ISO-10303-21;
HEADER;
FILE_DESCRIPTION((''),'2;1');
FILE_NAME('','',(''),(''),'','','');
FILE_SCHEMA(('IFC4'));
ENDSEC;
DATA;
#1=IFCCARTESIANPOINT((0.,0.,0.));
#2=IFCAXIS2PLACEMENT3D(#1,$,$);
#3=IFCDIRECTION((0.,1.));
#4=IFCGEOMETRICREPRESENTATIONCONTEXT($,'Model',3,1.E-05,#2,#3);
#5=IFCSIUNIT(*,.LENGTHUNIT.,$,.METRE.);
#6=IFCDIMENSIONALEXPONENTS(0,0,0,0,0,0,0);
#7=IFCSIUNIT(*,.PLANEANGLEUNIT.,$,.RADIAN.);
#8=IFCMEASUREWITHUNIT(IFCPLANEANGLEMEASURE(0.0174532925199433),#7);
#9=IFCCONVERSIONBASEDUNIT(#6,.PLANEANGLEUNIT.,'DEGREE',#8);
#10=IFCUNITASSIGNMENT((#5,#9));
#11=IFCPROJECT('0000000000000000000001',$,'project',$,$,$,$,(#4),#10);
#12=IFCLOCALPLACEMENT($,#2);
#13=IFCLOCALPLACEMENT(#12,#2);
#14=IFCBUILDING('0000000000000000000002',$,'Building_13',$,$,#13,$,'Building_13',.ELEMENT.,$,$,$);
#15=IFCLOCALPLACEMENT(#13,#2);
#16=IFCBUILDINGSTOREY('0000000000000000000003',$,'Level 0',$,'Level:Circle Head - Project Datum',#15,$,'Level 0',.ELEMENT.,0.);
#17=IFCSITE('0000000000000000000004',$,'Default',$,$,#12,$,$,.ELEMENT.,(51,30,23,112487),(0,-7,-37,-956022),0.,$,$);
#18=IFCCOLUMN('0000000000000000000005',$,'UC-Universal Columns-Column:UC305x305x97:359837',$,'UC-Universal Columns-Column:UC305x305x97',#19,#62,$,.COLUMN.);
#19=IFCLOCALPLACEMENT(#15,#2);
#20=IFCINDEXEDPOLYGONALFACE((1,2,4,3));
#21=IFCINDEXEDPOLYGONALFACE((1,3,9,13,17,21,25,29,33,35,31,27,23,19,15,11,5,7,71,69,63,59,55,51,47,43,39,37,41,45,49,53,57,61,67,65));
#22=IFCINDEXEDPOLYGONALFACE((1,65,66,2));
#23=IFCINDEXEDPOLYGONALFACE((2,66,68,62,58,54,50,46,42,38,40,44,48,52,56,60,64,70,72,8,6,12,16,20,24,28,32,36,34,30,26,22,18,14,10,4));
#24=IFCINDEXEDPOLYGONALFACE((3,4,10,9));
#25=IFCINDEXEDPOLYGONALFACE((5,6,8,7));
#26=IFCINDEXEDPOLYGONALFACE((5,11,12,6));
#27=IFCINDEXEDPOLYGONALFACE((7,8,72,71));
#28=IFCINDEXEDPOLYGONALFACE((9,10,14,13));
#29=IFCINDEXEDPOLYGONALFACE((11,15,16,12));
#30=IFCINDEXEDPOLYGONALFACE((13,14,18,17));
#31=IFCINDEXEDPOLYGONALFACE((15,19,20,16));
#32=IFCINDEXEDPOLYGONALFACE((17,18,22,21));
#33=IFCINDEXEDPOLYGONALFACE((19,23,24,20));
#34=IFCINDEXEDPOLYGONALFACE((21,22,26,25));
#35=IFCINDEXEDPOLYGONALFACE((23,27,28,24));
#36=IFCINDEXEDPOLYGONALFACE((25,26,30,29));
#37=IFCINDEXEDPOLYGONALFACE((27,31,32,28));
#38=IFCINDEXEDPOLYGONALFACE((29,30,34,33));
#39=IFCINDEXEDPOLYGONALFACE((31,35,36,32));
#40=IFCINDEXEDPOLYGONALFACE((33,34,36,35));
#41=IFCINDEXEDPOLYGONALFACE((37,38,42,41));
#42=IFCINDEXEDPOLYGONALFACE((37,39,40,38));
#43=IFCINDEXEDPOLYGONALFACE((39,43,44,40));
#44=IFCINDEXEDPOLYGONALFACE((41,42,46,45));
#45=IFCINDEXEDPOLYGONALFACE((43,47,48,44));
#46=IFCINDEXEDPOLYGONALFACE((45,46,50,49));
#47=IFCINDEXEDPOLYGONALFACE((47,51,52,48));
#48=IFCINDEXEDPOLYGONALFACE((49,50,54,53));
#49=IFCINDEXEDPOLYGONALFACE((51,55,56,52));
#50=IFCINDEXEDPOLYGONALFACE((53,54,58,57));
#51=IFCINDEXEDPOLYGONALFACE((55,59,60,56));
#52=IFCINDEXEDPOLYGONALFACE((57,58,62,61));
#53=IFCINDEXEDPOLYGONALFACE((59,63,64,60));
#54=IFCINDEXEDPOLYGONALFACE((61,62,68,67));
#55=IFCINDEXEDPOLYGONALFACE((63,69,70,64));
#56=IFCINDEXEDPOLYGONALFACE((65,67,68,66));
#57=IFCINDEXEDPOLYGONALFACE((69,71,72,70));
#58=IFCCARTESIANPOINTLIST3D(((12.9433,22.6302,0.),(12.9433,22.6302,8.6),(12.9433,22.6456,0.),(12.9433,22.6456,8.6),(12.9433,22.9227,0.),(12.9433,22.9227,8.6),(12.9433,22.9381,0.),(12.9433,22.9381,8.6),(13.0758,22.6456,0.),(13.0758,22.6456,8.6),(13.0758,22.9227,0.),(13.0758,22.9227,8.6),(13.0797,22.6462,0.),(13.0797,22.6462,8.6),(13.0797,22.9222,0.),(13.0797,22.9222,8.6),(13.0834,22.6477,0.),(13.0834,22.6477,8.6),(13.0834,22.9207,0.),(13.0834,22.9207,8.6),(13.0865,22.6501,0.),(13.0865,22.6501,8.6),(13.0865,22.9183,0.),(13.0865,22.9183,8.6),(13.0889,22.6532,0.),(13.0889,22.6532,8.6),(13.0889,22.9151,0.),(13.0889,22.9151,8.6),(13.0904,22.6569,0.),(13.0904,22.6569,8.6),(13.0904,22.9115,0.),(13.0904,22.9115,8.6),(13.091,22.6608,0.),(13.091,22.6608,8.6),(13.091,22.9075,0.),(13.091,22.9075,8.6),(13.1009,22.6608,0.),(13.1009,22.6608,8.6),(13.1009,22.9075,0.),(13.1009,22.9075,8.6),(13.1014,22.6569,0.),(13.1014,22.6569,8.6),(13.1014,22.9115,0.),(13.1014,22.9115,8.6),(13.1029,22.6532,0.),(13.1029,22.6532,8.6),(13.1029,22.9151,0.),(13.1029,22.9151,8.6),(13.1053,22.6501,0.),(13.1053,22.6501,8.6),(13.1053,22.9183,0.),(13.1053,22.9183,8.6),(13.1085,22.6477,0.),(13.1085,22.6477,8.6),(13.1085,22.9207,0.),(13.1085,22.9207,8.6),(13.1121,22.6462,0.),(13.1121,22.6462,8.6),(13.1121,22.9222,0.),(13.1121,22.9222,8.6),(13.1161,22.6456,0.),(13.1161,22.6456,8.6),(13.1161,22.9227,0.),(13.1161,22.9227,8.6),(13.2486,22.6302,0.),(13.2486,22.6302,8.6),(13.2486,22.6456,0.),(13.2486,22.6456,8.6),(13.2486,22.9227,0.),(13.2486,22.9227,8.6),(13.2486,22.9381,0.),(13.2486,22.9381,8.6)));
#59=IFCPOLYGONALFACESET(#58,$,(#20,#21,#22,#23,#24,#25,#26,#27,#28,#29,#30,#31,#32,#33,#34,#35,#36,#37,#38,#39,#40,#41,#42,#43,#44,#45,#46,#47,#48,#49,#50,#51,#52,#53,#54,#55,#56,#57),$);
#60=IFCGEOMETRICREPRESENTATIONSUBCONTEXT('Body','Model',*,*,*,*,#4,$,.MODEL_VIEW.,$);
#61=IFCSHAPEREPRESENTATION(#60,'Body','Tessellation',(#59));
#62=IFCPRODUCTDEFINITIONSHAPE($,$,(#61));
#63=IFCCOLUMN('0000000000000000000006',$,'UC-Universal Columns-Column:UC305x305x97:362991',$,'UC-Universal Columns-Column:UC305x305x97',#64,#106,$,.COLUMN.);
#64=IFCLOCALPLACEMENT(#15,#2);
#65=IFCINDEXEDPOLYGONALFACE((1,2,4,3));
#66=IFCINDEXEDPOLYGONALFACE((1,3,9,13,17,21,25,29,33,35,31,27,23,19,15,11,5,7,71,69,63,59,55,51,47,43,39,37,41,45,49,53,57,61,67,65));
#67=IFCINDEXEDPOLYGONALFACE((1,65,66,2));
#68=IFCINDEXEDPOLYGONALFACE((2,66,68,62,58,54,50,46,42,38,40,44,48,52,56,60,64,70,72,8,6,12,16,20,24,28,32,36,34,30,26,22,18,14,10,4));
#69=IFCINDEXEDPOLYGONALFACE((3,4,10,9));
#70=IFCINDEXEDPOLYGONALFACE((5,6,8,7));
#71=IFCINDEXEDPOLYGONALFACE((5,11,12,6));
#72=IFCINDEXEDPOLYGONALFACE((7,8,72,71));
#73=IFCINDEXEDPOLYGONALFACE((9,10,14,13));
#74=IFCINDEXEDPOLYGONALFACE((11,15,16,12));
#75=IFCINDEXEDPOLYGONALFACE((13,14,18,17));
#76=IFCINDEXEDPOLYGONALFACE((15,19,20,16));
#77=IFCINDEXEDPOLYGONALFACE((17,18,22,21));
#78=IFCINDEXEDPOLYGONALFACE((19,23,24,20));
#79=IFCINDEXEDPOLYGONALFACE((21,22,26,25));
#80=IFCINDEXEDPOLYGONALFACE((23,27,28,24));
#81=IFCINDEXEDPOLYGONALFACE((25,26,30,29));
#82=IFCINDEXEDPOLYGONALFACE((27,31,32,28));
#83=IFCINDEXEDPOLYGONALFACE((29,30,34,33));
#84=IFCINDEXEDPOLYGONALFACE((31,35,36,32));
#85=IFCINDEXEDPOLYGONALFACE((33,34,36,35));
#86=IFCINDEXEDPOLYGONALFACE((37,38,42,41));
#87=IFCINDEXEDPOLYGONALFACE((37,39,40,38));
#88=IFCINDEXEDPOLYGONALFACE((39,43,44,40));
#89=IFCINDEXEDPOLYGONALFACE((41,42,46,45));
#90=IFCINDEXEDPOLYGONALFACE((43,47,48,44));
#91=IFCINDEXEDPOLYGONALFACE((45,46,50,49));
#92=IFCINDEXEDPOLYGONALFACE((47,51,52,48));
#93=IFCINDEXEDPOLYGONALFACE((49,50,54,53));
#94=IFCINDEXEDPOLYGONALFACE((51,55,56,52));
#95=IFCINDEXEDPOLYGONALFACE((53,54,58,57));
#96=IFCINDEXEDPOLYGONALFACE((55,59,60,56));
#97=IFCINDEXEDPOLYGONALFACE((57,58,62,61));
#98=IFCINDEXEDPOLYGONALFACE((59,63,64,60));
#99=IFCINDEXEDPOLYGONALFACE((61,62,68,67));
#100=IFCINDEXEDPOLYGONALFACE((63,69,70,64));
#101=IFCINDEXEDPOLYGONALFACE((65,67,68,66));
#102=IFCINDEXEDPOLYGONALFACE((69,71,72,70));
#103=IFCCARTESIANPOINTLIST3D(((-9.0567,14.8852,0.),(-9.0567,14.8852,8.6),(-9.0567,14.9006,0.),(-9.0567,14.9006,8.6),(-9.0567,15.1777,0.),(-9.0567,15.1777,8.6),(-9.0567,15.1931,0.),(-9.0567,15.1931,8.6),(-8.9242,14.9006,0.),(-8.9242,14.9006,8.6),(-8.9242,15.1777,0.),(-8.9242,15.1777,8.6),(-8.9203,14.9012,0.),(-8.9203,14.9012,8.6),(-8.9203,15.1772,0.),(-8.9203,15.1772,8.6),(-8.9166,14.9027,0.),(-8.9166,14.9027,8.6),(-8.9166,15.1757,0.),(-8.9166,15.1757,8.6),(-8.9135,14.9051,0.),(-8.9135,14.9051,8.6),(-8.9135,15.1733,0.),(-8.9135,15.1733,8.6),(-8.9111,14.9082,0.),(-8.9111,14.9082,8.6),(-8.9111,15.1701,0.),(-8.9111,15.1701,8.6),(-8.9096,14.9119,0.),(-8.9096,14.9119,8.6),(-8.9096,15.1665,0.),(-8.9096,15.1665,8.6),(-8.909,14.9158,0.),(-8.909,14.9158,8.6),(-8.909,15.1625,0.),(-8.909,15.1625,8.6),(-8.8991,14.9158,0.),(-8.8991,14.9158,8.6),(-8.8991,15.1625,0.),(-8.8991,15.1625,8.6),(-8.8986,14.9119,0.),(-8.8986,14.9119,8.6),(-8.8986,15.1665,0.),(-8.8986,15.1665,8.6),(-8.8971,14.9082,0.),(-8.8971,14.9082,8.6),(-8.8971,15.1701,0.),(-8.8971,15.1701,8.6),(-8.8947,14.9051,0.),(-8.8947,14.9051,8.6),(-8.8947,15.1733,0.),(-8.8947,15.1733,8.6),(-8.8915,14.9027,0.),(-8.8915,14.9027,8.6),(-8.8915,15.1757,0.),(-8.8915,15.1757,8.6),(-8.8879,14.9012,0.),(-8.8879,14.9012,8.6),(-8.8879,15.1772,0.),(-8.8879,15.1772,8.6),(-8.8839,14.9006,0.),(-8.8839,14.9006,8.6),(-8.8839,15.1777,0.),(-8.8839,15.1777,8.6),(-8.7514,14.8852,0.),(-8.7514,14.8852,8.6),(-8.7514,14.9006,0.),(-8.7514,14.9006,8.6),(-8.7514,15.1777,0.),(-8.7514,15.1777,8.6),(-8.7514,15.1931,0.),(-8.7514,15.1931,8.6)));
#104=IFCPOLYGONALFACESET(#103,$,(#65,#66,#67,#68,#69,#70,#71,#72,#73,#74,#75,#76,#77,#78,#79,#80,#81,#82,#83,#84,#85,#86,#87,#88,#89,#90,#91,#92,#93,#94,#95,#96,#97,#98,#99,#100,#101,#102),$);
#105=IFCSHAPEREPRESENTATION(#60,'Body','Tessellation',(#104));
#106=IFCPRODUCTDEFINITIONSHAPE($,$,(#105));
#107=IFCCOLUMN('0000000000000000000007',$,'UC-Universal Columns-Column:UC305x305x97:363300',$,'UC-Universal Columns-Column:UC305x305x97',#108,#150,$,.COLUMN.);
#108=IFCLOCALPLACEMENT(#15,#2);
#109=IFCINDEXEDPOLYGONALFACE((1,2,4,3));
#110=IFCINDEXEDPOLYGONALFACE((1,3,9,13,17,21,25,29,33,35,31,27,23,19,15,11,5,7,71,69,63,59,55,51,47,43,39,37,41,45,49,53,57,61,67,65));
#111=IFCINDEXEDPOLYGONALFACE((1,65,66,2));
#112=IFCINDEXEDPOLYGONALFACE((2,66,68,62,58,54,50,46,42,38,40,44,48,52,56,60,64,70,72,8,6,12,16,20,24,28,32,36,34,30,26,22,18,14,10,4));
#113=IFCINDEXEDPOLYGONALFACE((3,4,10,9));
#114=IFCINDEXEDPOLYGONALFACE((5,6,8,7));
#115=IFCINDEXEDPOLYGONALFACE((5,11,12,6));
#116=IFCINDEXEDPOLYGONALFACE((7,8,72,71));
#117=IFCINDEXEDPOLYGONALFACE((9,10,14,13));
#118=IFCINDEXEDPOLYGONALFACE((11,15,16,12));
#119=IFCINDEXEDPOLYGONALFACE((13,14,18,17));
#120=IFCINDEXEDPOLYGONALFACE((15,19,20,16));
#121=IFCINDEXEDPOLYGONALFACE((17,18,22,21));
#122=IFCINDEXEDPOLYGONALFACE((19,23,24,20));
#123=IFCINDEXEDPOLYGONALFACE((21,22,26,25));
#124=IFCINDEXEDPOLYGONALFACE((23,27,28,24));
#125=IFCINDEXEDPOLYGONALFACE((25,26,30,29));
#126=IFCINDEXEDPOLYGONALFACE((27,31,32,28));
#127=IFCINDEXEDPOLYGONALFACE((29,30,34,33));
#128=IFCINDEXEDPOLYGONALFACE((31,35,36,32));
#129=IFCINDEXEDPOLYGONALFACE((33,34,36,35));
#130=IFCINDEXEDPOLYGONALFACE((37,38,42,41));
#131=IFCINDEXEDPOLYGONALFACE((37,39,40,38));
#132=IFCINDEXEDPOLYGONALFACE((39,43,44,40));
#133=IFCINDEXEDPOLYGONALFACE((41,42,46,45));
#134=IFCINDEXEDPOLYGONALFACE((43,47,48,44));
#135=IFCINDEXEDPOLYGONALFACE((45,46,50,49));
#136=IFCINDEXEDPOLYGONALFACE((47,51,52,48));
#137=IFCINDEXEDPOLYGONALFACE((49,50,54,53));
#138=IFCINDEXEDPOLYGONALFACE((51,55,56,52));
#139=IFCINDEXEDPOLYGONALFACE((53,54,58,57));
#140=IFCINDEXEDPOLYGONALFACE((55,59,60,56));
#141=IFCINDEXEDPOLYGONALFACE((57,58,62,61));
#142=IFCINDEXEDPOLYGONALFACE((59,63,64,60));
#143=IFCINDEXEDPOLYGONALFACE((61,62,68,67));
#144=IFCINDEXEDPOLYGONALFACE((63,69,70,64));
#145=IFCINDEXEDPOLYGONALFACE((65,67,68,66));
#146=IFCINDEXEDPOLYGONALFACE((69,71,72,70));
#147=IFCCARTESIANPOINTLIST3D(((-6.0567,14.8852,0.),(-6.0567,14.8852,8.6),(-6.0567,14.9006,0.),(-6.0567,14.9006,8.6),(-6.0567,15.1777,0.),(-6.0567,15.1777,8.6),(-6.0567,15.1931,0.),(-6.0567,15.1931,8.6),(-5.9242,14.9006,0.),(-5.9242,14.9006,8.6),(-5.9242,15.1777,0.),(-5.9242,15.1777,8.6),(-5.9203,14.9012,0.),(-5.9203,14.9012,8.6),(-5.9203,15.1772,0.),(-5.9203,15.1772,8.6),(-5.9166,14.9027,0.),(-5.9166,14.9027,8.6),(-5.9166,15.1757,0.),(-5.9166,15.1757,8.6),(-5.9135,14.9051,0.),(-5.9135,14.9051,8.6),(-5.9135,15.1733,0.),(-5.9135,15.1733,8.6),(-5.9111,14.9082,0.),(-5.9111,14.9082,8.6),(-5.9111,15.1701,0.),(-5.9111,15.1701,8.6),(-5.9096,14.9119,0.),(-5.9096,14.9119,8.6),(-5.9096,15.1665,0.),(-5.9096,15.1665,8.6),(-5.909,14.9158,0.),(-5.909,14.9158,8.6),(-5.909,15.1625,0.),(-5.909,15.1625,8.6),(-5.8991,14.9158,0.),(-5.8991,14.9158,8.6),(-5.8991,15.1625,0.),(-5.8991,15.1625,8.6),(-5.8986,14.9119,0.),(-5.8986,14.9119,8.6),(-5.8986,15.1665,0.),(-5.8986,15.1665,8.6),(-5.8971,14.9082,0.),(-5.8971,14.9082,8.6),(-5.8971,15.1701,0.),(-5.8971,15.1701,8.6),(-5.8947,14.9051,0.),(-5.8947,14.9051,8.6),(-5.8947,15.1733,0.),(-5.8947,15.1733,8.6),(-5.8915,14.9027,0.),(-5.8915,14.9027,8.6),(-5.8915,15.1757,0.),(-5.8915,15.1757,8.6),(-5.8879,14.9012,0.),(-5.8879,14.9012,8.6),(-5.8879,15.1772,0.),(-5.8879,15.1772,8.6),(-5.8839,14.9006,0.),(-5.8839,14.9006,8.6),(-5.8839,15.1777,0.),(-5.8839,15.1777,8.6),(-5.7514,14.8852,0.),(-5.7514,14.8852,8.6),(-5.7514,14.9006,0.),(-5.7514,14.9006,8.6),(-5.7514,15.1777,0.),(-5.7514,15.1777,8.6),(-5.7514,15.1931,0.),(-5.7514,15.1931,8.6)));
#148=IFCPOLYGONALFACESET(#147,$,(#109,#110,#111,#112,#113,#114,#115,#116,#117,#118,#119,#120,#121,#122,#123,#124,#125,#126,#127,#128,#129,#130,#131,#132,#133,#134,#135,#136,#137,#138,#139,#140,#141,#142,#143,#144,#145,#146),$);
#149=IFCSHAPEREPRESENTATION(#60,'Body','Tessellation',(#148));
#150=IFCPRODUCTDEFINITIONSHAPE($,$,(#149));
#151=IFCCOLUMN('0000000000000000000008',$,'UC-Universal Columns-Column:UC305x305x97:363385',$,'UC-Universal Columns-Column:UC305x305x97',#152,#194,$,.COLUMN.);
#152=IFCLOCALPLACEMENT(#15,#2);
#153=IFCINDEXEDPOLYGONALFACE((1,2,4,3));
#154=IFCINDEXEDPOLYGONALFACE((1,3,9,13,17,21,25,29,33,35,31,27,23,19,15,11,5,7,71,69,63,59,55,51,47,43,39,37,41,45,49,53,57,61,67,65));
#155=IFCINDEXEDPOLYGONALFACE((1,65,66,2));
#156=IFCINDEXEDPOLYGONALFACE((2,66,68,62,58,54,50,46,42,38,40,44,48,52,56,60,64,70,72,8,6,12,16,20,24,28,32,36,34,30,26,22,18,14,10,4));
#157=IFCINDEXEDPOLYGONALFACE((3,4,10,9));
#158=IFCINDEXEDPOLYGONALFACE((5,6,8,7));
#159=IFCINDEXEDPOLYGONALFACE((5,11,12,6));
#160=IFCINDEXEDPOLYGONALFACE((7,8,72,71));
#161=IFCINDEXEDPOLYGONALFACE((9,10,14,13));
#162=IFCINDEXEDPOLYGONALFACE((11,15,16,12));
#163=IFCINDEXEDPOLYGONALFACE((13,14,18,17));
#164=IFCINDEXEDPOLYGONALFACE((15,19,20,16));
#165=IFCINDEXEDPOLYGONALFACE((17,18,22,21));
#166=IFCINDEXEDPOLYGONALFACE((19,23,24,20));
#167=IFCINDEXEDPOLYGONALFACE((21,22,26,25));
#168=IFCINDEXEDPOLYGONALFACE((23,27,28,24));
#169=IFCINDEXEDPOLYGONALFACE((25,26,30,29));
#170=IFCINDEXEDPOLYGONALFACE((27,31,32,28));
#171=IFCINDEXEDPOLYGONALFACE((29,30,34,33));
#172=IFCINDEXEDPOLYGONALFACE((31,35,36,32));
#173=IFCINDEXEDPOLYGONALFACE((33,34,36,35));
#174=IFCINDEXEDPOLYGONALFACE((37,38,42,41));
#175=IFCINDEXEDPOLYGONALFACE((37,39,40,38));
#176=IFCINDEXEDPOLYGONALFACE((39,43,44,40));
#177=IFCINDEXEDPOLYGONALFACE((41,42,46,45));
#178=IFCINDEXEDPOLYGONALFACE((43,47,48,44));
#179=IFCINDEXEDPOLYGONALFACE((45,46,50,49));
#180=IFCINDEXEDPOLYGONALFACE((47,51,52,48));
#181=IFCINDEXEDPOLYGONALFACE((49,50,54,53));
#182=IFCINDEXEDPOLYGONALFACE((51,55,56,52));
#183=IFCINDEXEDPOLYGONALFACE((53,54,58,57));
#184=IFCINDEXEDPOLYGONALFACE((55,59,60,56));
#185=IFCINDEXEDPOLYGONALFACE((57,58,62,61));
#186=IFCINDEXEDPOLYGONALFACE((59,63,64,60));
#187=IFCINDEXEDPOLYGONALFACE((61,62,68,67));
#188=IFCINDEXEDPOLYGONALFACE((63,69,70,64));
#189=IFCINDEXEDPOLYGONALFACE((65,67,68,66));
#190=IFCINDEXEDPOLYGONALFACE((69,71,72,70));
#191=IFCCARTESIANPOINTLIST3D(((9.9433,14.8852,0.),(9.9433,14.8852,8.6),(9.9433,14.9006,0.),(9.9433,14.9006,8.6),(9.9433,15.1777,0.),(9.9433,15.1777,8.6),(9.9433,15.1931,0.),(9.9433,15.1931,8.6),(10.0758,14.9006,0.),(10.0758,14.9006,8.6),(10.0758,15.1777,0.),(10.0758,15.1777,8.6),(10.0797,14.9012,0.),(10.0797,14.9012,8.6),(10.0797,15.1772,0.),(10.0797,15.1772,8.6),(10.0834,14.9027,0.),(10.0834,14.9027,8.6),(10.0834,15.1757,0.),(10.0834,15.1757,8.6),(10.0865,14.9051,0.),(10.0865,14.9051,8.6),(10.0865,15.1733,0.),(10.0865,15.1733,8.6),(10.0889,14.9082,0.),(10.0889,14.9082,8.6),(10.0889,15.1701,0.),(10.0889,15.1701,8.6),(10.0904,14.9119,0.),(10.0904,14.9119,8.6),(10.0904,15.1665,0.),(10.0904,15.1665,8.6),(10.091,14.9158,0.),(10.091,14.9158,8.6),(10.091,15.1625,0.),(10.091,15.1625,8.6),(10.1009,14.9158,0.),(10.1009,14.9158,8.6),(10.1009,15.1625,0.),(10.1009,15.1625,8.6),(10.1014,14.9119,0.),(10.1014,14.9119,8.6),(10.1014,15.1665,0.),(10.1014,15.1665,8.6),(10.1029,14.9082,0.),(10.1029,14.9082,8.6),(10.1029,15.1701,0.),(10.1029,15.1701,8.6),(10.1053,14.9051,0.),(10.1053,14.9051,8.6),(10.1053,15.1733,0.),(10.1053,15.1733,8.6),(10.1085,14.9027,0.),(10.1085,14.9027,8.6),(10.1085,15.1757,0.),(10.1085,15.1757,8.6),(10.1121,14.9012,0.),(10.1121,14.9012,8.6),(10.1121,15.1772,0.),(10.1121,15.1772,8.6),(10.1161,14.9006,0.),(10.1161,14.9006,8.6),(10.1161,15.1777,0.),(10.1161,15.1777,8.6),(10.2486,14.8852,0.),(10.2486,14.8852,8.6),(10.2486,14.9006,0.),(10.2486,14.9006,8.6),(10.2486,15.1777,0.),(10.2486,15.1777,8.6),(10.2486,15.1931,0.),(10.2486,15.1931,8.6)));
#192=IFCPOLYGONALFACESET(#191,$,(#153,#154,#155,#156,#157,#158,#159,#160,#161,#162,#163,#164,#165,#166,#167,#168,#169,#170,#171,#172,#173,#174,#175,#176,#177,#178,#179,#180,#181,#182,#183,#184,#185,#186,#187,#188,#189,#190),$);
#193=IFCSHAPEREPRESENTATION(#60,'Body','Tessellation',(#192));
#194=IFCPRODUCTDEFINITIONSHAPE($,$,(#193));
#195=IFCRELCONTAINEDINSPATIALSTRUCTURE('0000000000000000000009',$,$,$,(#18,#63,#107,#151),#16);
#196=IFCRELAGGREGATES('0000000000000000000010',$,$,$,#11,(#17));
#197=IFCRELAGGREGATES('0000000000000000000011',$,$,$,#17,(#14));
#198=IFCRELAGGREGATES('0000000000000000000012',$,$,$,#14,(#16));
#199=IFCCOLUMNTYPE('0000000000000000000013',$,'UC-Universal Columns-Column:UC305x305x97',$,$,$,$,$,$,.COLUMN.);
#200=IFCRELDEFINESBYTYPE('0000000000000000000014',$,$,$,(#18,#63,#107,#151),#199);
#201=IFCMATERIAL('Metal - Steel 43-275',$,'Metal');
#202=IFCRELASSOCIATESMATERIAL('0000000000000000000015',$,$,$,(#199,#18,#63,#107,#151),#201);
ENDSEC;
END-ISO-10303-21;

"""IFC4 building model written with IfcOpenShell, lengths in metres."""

from ifc_helpers import new_model, entity, si_unit, converted_unit, direction, frame, origin, place, context, subcontext, project, spatial, line, arc, indexed_curve, outline, extrude, source, transform, mapped, material, type_object, type_shapes, element, save


model = new_model("IFC4")

# Units and contexts
model_context = context("Model", 3, precision=1e-05, world=origin(), true_north=direction((0.0, 1.0)))
body_context = subcontext(model_context, "Body", "Model", "MODEL_VIEW")
ifc_project = project(units=[si_unit("LENGTHUNIT", "METRE"), converted_unit("PLANEANGLEUNIT", "DEGREE", entity("IfcPlaneAngleMeasure", 0.0174532925199433), si_unit("PLANEANGLEUNIT", "RADIAN"), dimensions=[0, 0, 0, 0, 0, 0, 0])], contexts=[model_context])

# Site, building, storey
site_placement = place(None, origin())
site = spatial("IfcSite", under=ifc_project, at=site_placement, Name="Default", CompositionType="ELEMENT", RefLatitude=(51, 30, 23, 112487), RefLongitude=(0, -7, -37, -956022), RefElevation=0.0)
building_placement = place(site_placement, origin())
building = spatial("IfcBuilding", under=site, at=building_placement, Name="Building_13", LongName="Building_13", CompositionType="ELEMENT")
storey_placement = place(building_placement, origin())
storey = spatial("IfcBuildingStorey", under=building, at=storey_placement, Name="Level 0", ObjectType="Level:Circle Head - Project Datum", LongName="Level 0", CompositionType="ELEMENT", Elevation=0.0)

# Columns
ifc_material_1 = material(Name="Metal - Steel 43-275", Category="Metal")
column_type_1 = type_object("IfcColumnType", Name="UC-Universal Columns-Column:UC305x305x97", PredefinedType="COLUMN", material=ifc_material_1)
shared_shape_1 = source(origin(), body_context, "Body", "SweptSolid", [
    extrude(outline(indexed_curve([(-0.1527, -0.154), (0.1527, -0.154), (0.1527, -0.1386), (0.0202, -0.1386), (0.0094, -0.1341), (0.0049, -0.1234), (0.0049, 0.1234), (0.0094, 0.1341), (0.0202, 0.1386), (0.1527, 0.1386), (0.1527, 0.154), (-0.1527, 0.154), (-0.1527, 0.1386), (-0.0202, 0.1386), (-0.0094, 0.1341), (-0.005, 0.1234), (-0.005, -0.1234), (-0.0094, -0.1341), (-0.0202, -0.1386), (-0.1527, -0.1386)], segments=[line(1, 2, 3, 4), arc(4, 5, 6), line(6, 7), arc(7, 8, 9), line(9, 10, 11, 12, 13, 14), arc(14, 15, 16), line(16, 17), arc(17, 18, 19), line(19, 20, 1)], self_intersect=False)), frame((0.0, 0.0, 0.0), z_axis=(0.0, 0.0, 1.0), x_axis=(-1.0, 0.0, 0.0)), (0.0, 0.0, 1.0), 8.6),
])
type_shapes(column_type_1, [shared_shape_1])
for number, where, name in (
    (1, (13.0959, 22.7842, 0.0), "UC-Universal Columns-Column:UC305x305x97:359837"),
    (2, (-8.9041, 15.0392, 0.0), "UC-Universal Columns-Column:UC305x305x97:362991"),
    (3, (-5.9041, 15.0392, 0.0), "UC-Universal Columns-Column:UC305x305x97:363300"),
    (4, (10.0959, 15.0392, 0.0), "UC-Universal Columns-Column:UC305x305x97:363385"),
):
    element("IfcColumn", number, at=place(storey_placement, frame(where)), inside=storey, type_object=column_type_1, material=ifc_material_1, Name=name, ObjectType="UC-Universal Columns-Column:UC305x305x97", PredefinedType="COLUMN", context=body_context, shape_type="MappedRepresentation", body=[
        mapped(shared_shape_1, transform((0.0, 0.0, 0.0), scale=1.0)),
    ])

save(model, "model.ifc")
